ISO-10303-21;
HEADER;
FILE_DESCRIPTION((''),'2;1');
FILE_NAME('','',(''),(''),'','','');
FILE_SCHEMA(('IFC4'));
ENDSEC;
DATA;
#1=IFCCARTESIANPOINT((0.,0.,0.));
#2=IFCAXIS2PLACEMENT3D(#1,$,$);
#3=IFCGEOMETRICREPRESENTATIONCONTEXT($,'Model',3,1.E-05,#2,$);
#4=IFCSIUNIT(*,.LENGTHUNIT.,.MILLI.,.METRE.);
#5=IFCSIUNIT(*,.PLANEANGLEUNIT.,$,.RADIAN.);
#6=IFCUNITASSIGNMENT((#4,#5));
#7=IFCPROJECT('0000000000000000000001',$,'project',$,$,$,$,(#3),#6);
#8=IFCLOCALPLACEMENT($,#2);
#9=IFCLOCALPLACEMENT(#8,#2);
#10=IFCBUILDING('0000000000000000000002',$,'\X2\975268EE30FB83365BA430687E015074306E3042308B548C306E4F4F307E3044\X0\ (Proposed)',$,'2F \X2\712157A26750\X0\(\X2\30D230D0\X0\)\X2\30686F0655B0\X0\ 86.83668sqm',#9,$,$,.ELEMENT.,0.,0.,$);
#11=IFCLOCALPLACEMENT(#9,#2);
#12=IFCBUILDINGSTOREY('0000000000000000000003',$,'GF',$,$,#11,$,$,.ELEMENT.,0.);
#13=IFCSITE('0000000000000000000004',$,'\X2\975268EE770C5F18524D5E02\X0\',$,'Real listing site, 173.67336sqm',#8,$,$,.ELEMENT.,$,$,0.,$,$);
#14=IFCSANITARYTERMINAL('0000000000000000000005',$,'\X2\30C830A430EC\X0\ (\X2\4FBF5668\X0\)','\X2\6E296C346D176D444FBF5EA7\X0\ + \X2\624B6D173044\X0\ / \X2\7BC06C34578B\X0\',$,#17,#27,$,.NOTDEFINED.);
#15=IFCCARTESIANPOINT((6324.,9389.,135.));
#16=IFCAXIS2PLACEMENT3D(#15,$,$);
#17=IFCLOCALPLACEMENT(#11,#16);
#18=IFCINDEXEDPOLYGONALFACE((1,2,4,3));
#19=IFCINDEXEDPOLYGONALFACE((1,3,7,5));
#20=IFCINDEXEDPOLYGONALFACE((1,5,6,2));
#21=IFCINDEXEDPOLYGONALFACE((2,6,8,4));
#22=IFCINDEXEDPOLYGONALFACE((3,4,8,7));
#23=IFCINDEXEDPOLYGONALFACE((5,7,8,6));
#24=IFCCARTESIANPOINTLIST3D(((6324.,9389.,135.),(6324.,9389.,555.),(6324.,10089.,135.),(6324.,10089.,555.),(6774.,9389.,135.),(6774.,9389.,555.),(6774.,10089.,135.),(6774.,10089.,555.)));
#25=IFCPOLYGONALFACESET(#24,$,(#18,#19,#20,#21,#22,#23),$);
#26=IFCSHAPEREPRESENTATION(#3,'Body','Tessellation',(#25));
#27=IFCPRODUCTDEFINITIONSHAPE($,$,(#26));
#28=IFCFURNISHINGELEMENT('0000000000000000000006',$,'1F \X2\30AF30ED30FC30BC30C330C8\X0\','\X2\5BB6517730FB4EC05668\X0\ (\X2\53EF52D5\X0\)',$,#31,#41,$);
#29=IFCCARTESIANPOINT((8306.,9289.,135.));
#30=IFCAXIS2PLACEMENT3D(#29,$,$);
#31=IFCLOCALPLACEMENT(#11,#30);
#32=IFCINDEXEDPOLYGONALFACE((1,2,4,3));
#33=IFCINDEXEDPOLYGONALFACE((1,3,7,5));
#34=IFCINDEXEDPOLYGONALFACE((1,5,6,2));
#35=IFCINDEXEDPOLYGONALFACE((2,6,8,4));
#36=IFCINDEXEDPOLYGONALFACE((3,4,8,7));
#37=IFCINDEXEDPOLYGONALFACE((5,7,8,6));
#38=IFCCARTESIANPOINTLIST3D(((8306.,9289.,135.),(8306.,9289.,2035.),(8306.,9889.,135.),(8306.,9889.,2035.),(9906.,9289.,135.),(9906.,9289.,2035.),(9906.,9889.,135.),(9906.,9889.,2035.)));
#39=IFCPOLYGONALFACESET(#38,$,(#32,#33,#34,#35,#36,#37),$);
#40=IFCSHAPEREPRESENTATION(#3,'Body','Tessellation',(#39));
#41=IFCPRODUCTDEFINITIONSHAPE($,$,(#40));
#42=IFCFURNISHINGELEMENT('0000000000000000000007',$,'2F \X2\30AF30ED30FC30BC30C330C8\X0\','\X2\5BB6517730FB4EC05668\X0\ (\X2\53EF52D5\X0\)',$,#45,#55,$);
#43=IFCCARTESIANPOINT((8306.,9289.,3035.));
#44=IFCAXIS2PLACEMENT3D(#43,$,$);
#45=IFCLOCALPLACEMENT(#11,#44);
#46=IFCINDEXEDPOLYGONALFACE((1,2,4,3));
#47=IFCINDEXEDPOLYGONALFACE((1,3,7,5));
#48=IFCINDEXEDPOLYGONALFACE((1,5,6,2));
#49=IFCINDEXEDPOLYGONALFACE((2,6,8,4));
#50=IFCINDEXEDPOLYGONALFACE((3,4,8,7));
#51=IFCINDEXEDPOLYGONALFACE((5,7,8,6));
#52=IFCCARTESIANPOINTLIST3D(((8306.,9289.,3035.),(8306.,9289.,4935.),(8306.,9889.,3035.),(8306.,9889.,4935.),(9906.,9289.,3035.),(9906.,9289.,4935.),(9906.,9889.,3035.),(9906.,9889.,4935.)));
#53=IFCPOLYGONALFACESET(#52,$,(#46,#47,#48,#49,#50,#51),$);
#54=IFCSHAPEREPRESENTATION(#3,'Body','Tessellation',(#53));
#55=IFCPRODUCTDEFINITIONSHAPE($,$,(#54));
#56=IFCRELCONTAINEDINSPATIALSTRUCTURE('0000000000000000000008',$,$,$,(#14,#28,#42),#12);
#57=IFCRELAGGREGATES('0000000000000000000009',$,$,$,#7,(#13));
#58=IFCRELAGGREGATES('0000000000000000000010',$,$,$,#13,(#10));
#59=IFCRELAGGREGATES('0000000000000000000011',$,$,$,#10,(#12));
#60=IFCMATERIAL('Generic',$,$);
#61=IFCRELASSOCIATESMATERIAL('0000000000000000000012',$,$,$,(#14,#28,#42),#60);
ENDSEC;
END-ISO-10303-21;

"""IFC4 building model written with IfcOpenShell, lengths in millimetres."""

from ifc_helpers import new_model, si_unit, frame, frame_2d, origin, place, context, project, spatial, rectangle, extrude, material, element, save


model = new_model("IFC4")

# Units and contexts
model_context = context("Model", 3, precision=1e-05, world=origin())
ifc_project = project(units=[si_unit("LENGTHUNIT", "METRE", prefix="MILLI"), si_unit("PLANEANGLEUNIT", "RADIAN")], contexts=[model_context])

# Site, building, storey
site_placement = place(None, origin())
site = spatial("IfcSite", under=ifc_project, at=site_placement, Name="青森県弘前市", ObjectType="Real listing site, 173.67336sqm", CompositionType="ELEMENT", RefElevation=0.0)
building_placement = place(site_placement, origin())
building = spatial("IfcBuilding", under=site, at=building_placement, Name="青森・茶室と縁側のある和の住まい (Proposed)", ObjectType="2F 無垢材(ヒバ)と漆喰 86.83668sqm", CompositionType="ELEMENT", ElevationOfRefHeight=0.0, ElevationOfTerrain=0.0)
storey_placement = place(building_placement, origin())
storey = spatial("IfcBuildingStorey", under=building, at=storey_placement, Name="GF", CompositionType="ELEMENT", Elevation=0.0)

# Shared definitions
ifc_material_1 = material(Name="Generic")

# Sanitary terminal
sanitary_terminal_1_placement = place(storey_placement, frame((6324.0, 9389.0, 135.0)))
element("IfcSanitaryTerminal", 1, at=sanitary_terminal_1_placement, inside=storey, material=ifc_material_1, Name="トイレ (便器)", Description="温水洗浄便座 + 手洗い / 節水型", PredefinedType="NOTDEFINED", context=model_context, shape_type="SweptSolid", body=[
    extrude(rectangle(XDim=450.0, YDim=700.0, at=frame_2d((225.0, 350.0))), frame((6324.0, 9389.0, 135.0)), (0.0, 0.0, 1.0), 420.0),
])

# Furnishing elements
furnishing_1_placement = place(storey_placement, frame((8306.0, 9289.0, 135.0)))
element("IfcFurnishingElement", 2, at=furnishing_1_placement, inside=storey, material=ifc_material_1, Name="1F クローゼット", Description="家具・什器 (可動)", context=model_context, shape_type="SweptSolid", body=[
    extrude(rectangle(XDim=1600.0, YDim=600.0, at=frame_2d((800.0, 300.0))), frame((8306.0, 9289.0, 135.0)), (0.0, 0.0, 1.0), 1900.0),
])
furnishing_2_placement = place(storey_placement, frame((8306.0, 9289.0, 3035.0)))
element("IfcFurnishingElement", 3, at=furnishing_2_placement, inside=storey, material=ifc_material_1, Name="2F クローゼット", Description="家具・什器 (可動)", context=model_context, shape_type="SweptSolid", body=[
    extrude(rectangle(XDim=1600.0, YDim=600.0, at=frame_2d((800.0, 300.0))), frame((8306.0, 9289.0, 3035.0)), (0.0, 0.0, 1.0), 1900.0),
])

save(model, "model.ifc")
